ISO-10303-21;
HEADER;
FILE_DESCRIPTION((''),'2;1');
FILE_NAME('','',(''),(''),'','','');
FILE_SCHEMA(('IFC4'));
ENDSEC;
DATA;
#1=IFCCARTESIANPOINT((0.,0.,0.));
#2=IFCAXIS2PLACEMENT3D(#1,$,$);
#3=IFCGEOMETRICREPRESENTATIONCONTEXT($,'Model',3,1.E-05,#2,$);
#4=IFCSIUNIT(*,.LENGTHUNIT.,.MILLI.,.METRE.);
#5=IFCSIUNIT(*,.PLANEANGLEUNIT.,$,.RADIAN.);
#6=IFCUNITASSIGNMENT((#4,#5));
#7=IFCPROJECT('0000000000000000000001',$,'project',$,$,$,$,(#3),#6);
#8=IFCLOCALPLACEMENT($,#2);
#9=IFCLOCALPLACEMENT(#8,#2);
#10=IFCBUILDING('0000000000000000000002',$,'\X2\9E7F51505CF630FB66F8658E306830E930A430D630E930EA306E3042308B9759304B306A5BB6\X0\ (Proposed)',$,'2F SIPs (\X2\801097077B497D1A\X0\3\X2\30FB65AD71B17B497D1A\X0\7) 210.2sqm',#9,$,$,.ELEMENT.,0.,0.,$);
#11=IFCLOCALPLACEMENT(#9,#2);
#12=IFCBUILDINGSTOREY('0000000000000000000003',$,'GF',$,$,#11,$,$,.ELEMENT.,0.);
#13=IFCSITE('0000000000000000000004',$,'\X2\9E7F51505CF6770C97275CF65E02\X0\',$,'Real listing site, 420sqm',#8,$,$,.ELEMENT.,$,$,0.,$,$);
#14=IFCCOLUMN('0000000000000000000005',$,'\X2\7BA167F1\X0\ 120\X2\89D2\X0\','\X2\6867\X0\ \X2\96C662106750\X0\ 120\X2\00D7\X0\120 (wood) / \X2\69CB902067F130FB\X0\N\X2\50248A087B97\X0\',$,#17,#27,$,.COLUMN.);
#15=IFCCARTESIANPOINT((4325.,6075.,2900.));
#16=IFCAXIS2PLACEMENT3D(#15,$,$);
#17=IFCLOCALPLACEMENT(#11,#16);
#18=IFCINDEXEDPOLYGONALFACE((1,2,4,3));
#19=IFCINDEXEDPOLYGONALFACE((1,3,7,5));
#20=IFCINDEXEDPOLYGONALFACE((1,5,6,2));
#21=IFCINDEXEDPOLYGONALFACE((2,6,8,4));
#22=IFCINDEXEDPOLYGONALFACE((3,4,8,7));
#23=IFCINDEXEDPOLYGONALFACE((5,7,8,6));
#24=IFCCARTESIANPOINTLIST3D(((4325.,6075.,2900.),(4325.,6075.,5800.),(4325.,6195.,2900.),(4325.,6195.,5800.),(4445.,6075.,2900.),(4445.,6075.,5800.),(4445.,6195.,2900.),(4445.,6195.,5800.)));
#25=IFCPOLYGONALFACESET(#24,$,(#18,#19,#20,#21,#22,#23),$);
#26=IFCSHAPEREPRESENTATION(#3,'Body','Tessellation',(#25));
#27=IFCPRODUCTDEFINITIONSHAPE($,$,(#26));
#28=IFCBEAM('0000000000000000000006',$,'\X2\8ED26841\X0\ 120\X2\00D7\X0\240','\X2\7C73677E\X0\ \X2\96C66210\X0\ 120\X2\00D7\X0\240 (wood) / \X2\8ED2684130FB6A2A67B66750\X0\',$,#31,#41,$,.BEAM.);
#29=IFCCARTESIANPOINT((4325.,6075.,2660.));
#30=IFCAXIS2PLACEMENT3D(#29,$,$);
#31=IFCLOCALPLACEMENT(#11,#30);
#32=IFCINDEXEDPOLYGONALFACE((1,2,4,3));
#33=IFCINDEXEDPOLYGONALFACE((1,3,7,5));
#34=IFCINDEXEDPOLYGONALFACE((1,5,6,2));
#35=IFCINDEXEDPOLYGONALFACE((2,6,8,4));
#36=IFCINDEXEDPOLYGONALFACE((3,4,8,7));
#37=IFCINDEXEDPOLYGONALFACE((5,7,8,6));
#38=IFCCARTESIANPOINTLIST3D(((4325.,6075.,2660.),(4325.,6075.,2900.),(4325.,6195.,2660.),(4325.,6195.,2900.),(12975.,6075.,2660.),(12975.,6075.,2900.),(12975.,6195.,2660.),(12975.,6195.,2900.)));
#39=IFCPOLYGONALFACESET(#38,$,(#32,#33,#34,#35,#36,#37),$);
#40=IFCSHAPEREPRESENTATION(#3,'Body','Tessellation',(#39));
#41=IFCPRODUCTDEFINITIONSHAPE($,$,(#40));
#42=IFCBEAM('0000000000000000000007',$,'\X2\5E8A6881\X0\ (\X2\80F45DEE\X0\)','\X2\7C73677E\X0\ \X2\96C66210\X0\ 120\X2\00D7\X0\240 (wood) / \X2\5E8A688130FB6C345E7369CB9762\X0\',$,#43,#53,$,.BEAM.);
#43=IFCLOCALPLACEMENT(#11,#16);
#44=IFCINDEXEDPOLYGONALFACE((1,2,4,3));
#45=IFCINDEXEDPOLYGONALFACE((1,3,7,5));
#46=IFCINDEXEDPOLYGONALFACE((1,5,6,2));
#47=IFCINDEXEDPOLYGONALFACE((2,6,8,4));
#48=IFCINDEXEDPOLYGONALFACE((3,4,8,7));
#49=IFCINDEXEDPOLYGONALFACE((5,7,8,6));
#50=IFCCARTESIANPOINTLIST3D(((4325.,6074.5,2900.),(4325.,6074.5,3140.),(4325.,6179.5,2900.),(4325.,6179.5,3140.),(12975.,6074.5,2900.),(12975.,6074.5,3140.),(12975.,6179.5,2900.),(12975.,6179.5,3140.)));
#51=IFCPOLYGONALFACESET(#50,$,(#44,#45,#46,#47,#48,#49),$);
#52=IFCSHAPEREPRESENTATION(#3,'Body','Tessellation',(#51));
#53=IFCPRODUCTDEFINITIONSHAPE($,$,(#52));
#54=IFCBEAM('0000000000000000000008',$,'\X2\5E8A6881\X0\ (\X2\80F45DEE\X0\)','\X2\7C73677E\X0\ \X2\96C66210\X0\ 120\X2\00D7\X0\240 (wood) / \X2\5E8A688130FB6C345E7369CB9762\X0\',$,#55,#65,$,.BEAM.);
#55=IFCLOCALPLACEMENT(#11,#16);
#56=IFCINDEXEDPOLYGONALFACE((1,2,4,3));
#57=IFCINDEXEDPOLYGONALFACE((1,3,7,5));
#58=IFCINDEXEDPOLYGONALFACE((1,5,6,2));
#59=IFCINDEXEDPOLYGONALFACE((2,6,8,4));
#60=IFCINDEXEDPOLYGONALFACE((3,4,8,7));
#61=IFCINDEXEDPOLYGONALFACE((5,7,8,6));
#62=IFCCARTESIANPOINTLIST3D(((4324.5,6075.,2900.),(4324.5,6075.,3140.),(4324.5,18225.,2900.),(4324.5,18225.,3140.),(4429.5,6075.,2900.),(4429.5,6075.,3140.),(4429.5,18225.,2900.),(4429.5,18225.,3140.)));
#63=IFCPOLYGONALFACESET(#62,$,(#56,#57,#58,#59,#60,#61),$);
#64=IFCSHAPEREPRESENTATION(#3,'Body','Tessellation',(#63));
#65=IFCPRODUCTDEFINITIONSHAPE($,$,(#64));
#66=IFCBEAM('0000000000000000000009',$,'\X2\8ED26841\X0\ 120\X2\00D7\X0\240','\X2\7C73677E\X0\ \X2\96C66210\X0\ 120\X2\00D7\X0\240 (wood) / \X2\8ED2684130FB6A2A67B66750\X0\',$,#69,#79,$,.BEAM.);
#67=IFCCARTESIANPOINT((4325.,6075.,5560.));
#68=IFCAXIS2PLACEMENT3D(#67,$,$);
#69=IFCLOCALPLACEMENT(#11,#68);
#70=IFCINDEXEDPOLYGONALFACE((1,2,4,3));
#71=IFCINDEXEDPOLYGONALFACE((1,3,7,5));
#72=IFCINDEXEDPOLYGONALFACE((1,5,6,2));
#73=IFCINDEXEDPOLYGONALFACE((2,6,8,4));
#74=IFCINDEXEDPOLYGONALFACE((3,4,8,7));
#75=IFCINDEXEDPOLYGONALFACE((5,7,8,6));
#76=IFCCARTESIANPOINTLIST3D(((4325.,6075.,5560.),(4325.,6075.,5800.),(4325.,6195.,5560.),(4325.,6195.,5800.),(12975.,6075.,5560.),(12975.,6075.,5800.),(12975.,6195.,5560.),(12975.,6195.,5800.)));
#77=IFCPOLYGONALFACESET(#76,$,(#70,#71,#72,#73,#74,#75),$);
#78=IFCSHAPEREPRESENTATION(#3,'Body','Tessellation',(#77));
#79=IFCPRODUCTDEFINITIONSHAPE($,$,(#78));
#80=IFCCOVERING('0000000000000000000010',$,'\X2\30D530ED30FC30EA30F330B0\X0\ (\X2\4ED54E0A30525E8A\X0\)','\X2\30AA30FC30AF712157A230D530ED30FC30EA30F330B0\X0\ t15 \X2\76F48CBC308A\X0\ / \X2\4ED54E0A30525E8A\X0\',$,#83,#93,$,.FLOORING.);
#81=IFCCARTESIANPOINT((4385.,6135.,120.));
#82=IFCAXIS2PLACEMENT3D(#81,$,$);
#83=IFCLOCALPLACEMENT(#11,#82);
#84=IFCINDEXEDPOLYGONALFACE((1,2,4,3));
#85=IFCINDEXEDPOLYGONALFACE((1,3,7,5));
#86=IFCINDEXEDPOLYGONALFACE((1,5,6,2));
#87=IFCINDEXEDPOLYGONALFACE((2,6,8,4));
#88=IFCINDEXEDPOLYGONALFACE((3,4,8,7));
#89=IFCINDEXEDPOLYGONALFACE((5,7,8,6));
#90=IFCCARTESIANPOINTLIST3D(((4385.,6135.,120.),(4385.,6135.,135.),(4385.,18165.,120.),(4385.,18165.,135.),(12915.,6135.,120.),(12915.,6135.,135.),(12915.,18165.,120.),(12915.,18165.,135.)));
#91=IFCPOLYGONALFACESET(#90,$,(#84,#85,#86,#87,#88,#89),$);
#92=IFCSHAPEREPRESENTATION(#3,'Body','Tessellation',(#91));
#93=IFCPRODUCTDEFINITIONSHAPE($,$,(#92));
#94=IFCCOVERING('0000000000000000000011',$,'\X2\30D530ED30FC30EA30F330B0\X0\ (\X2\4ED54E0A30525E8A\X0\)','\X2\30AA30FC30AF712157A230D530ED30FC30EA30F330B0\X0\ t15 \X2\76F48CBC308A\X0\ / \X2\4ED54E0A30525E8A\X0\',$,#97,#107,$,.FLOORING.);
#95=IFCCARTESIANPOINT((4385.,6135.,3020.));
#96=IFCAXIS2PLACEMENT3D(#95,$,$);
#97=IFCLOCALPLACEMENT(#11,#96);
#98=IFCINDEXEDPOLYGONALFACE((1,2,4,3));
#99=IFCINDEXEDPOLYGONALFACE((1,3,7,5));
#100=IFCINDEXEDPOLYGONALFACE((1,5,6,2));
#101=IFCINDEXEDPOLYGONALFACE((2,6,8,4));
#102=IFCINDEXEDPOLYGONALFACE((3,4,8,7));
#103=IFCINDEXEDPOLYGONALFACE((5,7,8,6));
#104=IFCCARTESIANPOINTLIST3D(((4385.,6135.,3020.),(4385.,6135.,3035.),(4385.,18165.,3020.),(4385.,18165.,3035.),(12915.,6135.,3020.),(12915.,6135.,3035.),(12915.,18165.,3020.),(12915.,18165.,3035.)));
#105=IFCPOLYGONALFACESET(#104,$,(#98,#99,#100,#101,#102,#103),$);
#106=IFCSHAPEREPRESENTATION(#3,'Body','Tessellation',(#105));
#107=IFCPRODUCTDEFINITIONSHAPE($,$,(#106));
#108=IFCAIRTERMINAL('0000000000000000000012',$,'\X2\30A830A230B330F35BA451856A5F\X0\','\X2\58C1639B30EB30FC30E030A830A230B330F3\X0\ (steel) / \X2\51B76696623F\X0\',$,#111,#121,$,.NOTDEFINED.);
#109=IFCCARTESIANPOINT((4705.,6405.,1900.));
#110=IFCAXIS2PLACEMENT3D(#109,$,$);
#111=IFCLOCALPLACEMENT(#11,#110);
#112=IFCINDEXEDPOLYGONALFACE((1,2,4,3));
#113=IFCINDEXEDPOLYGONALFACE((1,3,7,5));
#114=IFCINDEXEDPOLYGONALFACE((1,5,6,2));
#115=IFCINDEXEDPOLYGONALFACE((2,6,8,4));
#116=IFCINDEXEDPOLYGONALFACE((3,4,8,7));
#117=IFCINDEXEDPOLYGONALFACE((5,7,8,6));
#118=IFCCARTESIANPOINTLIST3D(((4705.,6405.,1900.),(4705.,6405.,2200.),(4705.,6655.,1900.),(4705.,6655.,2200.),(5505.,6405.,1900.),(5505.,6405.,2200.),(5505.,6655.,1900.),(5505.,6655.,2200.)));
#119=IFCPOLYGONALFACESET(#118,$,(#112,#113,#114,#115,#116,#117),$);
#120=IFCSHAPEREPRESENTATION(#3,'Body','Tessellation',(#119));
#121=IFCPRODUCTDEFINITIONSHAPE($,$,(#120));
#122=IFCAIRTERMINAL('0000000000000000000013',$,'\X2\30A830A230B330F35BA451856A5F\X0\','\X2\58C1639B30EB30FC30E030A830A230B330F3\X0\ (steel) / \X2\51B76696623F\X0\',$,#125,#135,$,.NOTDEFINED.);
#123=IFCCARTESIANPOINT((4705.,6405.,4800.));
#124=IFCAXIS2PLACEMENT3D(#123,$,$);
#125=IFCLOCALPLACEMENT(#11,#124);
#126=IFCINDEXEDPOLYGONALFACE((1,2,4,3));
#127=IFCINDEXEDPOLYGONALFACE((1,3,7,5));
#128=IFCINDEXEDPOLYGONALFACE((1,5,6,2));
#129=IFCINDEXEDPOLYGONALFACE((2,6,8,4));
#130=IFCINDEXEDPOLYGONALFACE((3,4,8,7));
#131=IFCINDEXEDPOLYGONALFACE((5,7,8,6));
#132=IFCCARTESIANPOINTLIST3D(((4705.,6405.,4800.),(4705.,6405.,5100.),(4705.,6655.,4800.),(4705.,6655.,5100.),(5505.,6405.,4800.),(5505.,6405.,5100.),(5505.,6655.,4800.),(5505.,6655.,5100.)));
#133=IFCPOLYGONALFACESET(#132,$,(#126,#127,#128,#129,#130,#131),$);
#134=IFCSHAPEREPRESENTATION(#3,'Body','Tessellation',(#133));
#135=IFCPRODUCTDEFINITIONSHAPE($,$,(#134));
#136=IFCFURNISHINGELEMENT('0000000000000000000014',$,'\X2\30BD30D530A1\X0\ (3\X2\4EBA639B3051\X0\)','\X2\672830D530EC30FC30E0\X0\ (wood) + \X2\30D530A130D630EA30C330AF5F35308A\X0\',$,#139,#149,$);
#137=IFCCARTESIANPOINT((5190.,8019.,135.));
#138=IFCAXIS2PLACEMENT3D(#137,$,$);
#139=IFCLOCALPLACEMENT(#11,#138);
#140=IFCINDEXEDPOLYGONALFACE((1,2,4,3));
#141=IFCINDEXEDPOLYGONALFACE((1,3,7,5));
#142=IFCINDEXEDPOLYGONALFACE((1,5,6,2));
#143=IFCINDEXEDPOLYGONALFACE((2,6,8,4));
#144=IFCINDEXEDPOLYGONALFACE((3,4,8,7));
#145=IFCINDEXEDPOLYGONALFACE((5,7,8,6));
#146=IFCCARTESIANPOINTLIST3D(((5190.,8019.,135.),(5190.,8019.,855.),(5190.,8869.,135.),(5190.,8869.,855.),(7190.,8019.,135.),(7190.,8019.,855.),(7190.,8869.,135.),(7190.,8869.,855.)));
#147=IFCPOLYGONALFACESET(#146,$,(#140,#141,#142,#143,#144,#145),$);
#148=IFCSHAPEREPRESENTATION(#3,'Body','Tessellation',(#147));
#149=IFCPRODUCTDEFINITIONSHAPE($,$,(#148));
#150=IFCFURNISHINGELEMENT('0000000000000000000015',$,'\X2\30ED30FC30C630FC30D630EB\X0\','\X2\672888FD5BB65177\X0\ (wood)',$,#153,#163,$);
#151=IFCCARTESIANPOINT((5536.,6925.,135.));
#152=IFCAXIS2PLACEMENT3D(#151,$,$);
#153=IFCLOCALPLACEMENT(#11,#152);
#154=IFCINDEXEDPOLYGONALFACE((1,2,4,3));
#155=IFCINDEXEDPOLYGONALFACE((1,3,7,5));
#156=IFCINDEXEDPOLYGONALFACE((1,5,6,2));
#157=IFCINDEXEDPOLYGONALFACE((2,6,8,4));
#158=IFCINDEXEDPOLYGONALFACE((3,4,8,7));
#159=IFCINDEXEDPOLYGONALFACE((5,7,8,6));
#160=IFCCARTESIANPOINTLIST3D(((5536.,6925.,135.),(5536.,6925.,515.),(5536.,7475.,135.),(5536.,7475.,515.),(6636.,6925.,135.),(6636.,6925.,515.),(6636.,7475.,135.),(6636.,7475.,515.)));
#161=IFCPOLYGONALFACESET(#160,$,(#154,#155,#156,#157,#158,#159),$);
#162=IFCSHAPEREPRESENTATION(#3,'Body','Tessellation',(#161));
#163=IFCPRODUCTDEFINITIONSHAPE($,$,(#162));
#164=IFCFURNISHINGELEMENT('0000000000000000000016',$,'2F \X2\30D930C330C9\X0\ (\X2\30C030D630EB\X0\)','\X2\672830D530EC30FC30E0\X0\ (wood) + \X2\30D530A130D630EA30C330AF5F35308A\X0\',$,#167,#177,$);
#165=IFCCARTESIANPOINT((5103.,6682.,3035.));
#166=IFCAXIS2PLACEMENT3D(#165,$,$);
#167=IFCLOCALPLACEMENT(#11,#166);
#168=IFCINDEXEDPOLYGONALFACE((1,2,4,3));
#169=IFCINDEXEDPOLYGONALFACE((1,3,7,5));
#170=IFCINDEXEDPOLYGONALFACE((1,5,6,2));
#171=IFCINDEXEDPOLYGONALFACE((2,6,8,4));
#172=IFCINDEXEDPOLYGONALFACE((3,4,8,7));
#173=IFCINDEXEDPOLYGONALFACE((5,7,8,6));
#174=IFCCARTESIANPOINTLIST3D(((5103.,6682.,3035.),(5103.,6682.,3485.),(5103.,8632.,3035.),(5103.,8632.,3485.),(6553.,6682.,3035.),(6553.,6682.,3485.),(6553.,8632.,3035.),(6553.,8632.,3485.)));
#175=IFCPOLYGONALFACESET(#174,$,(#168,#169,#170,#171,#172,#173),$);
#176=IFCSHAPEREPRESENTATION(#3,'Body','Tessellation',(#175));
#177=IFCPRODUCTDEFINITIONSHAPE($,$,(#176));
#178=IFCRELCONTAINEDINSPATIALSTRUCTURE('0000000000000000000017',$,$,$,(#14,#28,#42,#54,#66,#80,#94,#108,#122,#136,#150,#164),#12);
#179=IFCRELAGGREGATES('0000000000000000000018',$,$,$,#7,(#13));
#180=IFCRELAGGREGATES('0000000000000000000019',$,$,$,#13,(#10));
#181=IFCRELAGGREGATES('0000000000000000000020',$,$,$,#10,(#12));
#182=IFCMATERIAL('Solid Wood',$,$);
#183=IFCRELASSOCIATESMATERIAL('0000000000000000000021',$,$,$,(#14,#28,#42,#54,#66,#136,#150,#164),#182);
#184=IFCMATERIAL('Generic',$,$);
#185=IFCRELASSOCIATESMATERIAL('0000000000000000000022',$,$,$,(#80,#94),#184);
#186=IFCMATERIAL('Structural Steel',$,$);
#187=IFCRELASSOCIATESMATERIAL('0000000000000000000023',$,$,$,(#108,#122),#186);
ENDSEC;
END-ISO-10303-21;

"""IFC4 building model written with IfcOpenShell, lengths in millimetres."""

from ifc_helpers import new_model, si_unit, frame, frame_2d, origin, place, context, project, spatial, rectangle, extrude, material, element, save


model = new_model("IFC4")

# Units and contexts
model_context = context("Model", 3, precision=1e-05, world=origin())
ifc_project = project(units=[si_unit("LENGTHUNIT", "METRE", prefix="MILLI"), si_unit("PLANEANGLEUNIT", "RADIAN")], contexts=[model_context])

# Site, building, storey
site_placement = place(None, origin())
site = spatial("IfcSite", under=ifc_project, at=site_placement, Name="鹿児島県霧島市", ObjectType="Real listing site, 420sqm", CompositionType="ELEMENT", RefElevation=0.0)
building_placement = place(site_placement, origin())
building = spatial("IfcBuilding", under=site, at=building_placement, Name="鹿児島・書斎とライブラリのある静かな家 (Proposed)", ObjectType="2F SIPs (耐震等級3・断熱等級7) 210.2sqm", CompositionType="ELEMENT", ElevationOfRefHeight=0.0, ElevationOfTerrain=0.0)
storey_placement = place(building_placement, origin())
storey = spatial("IfcBuildingStorey", under=building, at=storey_placement, Name="GF", CompositionType="ELEMENT", Elevation=0.0)

# Column
ifc_material_1 = material(Name="Solid Wood")
column_1_placement = place(storey_placement, frame((4325.0, 6075.0, 2900.0)))
element("IfcColumn", 1, at=column_1_placement, inside=storey, material=ifc_material_1, Name="管柱 120角", Description="桧 集成材 120×120 (wood) / 構造柱・N値計算", PredefinedType="COLUMN", context=model_context, shape_type="SweptSolid", body=[
    extrude(rectangle(XDim=120.0, YDim=120.0, at=frame_2d((60.0, 60.0))), frame((4325.0, 6075.0, 2900.0)), (0.0, 0.0, 1.0), 2900.0),
])

# Beams
beam_1_placement = place(storey_placement, frame((4325.0, 6075.0, 2660.0)))
element("IfcBeam", 2, at=beam_1_placement, inside=storey, material=ifc_material_1, Name="軒桁 120×240", Description="米松 集成 120×240 (wood) / 軒桁・横架材", PredefinedType="BEAM", context=model_context, shape_type="SweptSolid", body=[
    extrude(rectangle(XDim=8650.0, YDim=120.0, at=frame_2d((4325.0, 60.0))), frame((4325.0, 6075.0, 2660.0)), (0.0, 0.0, 1.0), 240.0),
])
beam_2_placement = place(storey_placement, frame((4325.0, 6075.0, 2900.0)))
element("IfcBeam", 3, at=beam_2_placement, inside=storey, material=ifc_material_1, Name="床梁 (胴差)", Description="米松 集成 120×240 (wood) / 床梁・水平構面", PredefinedType="BEAM", context=model_context, shape_type="SweptSolid", body=[
    extrude(rectangle(XDim=8650.0, YDim=105.0, at=frame_2d((4325.0, 52.0))), frame((4325.0, 6075.0, 2900.0)), (0.0, 0.0, 1.0), 240.0),
])
beam_3_placement = place(storey_placement, frame((4325.0, 6075.0, 2900.0)))
element("IfcBeam", 4, at=beam_3_placement, inside=storey, material=ifc_material_1, Name="床梁 (胴差)", Description="米松 集成 120×240 (wood) / 床梁・水平構面", PredefinedType="BEAM", context=model_context, shape_type="SweptSolid", body=[
    extrude(rectangle(XDim=105.0, YDim=12150.0, at=frame_2d((52.0, 6075.0))), frame((4325.0, 6075.0, 2900.0)), (0.0, 0.0, 1.0), 240.0),
])
beam_4_placement = place(storey_placement, frame((4325.0, 6075.0, 5560.0)))
element("IfcBeam", 5, at=beam_4_placement, inside=storey, material=ifc_material_1, Name="軒桁 120×240", Description="米松 集成 120×240 (wood) / 軒桁・横架材", PredefinedType="BEAM", context=model_context, shape_type="SweptSolid", body=[
    extrude(rectangle(XDim=8650.0, YDim=120.0, at=frame_2d((4325.0, 60.0))), frame((4325.0, 6075.0, 5560.0)), (0.0, 0.0, 1.0), 240.0),
])

# Coverings
ifc_material_2 = material(Name="Generic")
covering_1_placement = place(storey_placement, frame((4385.0, 6135.0, 120.0)))
element("IfcCovering", 6, at=covering_1_placement, inside=storey, material=ifc_material_2, Name="フローリング (仕上げ床)", Description="オーク無垢フローリング t15 直貼り / 仕上げ床", PredefinedType="FLOORING", context=model_context, shape_type="SweptSolid", body=[
    extrude(rectangle(XDim=8530.0, YDim=12030.0, at=frame_2d((4265.0, 6015.0))), frame((4385.0, 6135.0, 120.0)), (0.0, 0.0, 1.0), 15.0),
])
covering_2_placement = place(storey_placement, frame((4385.0, 6135.0, 3020.0)))
element("IfcCovering", 7, at=covering_2_placement, inside=storey, material=ifc_material_2, Name="フローリング (仕上げ床)", Description="オーク無垢フローリング t15 直貼り / 仕上げ床", PredefinedType="FLOORING", context=model_context, shape_type="SweptSolid", body=[
    extrude(rectangle(XDim=8530.0, YDim=12030.0, at=frame_2d((4265.0, 6015.0))), frame((4385.0, 6135.0, 3020.0)), (0.0, 0.0, 1.0), 15.0),
])

# Air terminals
ifc_material_3 = material(Name="Structural Steel")
air_terminal_1_placement = place(storey_placement, frame((4705.0, 6405.0, 1900.0)))
element("IfcAirTerminal", 8, at=air_terminal_1_placement, inside=storey, material=ifc_material_3, Name="エアコン室内機", Description="壁掛ルームエアコン (steel) / 冷暖房", PredefinedType="NOTDEFINED", context=model_context, shape_type="SweptSolid", body=[
    extrude(rectangle(XDim=800.0, YDim=250.0, at=frame_2d((400.0, 125.0))), frame((4705.0, 6405.0, 1900.0)), (0.0, 0.0, 1.0), 300.0),
])
air_terminal_2_placement = place(storey_placement, frame((4705.0, 6405.0, 4800.0)))
element("IfcAirTerminal", 9, at=air_terminal_2_placement, inside=storey, material=ifc_material_3, Name="エアコン室内機", Description="壁掛ルームエアコン (steel) / 冷暖房", PredefinedType="NOTDEFINED", context=model_context, shape_type="SweptSolid", body=[
    extrude(rectangle(XDim=800.0, YDim=250.0, at=frame_2d((400.0, 125.0))), frame((4705.0, 6405.0, 4800.0)), (0.0, 0.0, 1.0), 300.0),
])

# Furnishing elements
furnishing_1_placement = place(storey_placement, frame((5190.0, 8019.0, 135.0)))
element("IfcFurnishingElement", 10, at=furnishing_1_placement, inside=storey, material=ifc_material_1, Name="ソファ (3人掛け)", Description="木フレーム (wood) + ファブリック張り", context=model_context, shape_type="SweptSolid", body=[
    extrude(rectangle(XDim=2000.0, YDim=850.0, at=frame_2d((1000.0, 425.0))), frame((5190.0, 8019.0, 135.0)), (0.0, 0.0, 1.0), 720.0),
])
furnishing_2_placement = place(storey_placement, frame((5536.0, 6925.0, 135.0)))
element("IfcFurnishingElement", 11, at=furnishing_2_placement, inside=storey, material=ifc_material_1, Name="ローテーブル", Description="木製家具 (wood)", context=model_context, shape_type="SweptSolid", body=[
    extrude(rectangle(XDim=1100.0, YDim=550.0, at=frame_2d((550.0, 275.0))), frame((5536.0, 6925.0, 135.0)), (0.0, 0.0, 1.0), 380.0),
])
furnishing_3_placement = place(storey_placement, frame((5103.0, 6682.0, 3035.0)))
element("IfcFurnishingElement", 12, at=furnishing_3_placement, inside=storey, material=ifc_material_1, Name="2F ベッド (ダブル)", Description="木フレーム (wood) + ファブリック張り", context=model_context, shape_type="SweptSolid", body=[
    extrude(rectangle(XDim=1450.0, YDim=1950.0, at=frame_2d((725.0, 975.0))), frame((5103.0, 6682.0, 3035.0)), (0.0, 0.0, 1.0), 450.0),
])

save(model, "model.ifc")
